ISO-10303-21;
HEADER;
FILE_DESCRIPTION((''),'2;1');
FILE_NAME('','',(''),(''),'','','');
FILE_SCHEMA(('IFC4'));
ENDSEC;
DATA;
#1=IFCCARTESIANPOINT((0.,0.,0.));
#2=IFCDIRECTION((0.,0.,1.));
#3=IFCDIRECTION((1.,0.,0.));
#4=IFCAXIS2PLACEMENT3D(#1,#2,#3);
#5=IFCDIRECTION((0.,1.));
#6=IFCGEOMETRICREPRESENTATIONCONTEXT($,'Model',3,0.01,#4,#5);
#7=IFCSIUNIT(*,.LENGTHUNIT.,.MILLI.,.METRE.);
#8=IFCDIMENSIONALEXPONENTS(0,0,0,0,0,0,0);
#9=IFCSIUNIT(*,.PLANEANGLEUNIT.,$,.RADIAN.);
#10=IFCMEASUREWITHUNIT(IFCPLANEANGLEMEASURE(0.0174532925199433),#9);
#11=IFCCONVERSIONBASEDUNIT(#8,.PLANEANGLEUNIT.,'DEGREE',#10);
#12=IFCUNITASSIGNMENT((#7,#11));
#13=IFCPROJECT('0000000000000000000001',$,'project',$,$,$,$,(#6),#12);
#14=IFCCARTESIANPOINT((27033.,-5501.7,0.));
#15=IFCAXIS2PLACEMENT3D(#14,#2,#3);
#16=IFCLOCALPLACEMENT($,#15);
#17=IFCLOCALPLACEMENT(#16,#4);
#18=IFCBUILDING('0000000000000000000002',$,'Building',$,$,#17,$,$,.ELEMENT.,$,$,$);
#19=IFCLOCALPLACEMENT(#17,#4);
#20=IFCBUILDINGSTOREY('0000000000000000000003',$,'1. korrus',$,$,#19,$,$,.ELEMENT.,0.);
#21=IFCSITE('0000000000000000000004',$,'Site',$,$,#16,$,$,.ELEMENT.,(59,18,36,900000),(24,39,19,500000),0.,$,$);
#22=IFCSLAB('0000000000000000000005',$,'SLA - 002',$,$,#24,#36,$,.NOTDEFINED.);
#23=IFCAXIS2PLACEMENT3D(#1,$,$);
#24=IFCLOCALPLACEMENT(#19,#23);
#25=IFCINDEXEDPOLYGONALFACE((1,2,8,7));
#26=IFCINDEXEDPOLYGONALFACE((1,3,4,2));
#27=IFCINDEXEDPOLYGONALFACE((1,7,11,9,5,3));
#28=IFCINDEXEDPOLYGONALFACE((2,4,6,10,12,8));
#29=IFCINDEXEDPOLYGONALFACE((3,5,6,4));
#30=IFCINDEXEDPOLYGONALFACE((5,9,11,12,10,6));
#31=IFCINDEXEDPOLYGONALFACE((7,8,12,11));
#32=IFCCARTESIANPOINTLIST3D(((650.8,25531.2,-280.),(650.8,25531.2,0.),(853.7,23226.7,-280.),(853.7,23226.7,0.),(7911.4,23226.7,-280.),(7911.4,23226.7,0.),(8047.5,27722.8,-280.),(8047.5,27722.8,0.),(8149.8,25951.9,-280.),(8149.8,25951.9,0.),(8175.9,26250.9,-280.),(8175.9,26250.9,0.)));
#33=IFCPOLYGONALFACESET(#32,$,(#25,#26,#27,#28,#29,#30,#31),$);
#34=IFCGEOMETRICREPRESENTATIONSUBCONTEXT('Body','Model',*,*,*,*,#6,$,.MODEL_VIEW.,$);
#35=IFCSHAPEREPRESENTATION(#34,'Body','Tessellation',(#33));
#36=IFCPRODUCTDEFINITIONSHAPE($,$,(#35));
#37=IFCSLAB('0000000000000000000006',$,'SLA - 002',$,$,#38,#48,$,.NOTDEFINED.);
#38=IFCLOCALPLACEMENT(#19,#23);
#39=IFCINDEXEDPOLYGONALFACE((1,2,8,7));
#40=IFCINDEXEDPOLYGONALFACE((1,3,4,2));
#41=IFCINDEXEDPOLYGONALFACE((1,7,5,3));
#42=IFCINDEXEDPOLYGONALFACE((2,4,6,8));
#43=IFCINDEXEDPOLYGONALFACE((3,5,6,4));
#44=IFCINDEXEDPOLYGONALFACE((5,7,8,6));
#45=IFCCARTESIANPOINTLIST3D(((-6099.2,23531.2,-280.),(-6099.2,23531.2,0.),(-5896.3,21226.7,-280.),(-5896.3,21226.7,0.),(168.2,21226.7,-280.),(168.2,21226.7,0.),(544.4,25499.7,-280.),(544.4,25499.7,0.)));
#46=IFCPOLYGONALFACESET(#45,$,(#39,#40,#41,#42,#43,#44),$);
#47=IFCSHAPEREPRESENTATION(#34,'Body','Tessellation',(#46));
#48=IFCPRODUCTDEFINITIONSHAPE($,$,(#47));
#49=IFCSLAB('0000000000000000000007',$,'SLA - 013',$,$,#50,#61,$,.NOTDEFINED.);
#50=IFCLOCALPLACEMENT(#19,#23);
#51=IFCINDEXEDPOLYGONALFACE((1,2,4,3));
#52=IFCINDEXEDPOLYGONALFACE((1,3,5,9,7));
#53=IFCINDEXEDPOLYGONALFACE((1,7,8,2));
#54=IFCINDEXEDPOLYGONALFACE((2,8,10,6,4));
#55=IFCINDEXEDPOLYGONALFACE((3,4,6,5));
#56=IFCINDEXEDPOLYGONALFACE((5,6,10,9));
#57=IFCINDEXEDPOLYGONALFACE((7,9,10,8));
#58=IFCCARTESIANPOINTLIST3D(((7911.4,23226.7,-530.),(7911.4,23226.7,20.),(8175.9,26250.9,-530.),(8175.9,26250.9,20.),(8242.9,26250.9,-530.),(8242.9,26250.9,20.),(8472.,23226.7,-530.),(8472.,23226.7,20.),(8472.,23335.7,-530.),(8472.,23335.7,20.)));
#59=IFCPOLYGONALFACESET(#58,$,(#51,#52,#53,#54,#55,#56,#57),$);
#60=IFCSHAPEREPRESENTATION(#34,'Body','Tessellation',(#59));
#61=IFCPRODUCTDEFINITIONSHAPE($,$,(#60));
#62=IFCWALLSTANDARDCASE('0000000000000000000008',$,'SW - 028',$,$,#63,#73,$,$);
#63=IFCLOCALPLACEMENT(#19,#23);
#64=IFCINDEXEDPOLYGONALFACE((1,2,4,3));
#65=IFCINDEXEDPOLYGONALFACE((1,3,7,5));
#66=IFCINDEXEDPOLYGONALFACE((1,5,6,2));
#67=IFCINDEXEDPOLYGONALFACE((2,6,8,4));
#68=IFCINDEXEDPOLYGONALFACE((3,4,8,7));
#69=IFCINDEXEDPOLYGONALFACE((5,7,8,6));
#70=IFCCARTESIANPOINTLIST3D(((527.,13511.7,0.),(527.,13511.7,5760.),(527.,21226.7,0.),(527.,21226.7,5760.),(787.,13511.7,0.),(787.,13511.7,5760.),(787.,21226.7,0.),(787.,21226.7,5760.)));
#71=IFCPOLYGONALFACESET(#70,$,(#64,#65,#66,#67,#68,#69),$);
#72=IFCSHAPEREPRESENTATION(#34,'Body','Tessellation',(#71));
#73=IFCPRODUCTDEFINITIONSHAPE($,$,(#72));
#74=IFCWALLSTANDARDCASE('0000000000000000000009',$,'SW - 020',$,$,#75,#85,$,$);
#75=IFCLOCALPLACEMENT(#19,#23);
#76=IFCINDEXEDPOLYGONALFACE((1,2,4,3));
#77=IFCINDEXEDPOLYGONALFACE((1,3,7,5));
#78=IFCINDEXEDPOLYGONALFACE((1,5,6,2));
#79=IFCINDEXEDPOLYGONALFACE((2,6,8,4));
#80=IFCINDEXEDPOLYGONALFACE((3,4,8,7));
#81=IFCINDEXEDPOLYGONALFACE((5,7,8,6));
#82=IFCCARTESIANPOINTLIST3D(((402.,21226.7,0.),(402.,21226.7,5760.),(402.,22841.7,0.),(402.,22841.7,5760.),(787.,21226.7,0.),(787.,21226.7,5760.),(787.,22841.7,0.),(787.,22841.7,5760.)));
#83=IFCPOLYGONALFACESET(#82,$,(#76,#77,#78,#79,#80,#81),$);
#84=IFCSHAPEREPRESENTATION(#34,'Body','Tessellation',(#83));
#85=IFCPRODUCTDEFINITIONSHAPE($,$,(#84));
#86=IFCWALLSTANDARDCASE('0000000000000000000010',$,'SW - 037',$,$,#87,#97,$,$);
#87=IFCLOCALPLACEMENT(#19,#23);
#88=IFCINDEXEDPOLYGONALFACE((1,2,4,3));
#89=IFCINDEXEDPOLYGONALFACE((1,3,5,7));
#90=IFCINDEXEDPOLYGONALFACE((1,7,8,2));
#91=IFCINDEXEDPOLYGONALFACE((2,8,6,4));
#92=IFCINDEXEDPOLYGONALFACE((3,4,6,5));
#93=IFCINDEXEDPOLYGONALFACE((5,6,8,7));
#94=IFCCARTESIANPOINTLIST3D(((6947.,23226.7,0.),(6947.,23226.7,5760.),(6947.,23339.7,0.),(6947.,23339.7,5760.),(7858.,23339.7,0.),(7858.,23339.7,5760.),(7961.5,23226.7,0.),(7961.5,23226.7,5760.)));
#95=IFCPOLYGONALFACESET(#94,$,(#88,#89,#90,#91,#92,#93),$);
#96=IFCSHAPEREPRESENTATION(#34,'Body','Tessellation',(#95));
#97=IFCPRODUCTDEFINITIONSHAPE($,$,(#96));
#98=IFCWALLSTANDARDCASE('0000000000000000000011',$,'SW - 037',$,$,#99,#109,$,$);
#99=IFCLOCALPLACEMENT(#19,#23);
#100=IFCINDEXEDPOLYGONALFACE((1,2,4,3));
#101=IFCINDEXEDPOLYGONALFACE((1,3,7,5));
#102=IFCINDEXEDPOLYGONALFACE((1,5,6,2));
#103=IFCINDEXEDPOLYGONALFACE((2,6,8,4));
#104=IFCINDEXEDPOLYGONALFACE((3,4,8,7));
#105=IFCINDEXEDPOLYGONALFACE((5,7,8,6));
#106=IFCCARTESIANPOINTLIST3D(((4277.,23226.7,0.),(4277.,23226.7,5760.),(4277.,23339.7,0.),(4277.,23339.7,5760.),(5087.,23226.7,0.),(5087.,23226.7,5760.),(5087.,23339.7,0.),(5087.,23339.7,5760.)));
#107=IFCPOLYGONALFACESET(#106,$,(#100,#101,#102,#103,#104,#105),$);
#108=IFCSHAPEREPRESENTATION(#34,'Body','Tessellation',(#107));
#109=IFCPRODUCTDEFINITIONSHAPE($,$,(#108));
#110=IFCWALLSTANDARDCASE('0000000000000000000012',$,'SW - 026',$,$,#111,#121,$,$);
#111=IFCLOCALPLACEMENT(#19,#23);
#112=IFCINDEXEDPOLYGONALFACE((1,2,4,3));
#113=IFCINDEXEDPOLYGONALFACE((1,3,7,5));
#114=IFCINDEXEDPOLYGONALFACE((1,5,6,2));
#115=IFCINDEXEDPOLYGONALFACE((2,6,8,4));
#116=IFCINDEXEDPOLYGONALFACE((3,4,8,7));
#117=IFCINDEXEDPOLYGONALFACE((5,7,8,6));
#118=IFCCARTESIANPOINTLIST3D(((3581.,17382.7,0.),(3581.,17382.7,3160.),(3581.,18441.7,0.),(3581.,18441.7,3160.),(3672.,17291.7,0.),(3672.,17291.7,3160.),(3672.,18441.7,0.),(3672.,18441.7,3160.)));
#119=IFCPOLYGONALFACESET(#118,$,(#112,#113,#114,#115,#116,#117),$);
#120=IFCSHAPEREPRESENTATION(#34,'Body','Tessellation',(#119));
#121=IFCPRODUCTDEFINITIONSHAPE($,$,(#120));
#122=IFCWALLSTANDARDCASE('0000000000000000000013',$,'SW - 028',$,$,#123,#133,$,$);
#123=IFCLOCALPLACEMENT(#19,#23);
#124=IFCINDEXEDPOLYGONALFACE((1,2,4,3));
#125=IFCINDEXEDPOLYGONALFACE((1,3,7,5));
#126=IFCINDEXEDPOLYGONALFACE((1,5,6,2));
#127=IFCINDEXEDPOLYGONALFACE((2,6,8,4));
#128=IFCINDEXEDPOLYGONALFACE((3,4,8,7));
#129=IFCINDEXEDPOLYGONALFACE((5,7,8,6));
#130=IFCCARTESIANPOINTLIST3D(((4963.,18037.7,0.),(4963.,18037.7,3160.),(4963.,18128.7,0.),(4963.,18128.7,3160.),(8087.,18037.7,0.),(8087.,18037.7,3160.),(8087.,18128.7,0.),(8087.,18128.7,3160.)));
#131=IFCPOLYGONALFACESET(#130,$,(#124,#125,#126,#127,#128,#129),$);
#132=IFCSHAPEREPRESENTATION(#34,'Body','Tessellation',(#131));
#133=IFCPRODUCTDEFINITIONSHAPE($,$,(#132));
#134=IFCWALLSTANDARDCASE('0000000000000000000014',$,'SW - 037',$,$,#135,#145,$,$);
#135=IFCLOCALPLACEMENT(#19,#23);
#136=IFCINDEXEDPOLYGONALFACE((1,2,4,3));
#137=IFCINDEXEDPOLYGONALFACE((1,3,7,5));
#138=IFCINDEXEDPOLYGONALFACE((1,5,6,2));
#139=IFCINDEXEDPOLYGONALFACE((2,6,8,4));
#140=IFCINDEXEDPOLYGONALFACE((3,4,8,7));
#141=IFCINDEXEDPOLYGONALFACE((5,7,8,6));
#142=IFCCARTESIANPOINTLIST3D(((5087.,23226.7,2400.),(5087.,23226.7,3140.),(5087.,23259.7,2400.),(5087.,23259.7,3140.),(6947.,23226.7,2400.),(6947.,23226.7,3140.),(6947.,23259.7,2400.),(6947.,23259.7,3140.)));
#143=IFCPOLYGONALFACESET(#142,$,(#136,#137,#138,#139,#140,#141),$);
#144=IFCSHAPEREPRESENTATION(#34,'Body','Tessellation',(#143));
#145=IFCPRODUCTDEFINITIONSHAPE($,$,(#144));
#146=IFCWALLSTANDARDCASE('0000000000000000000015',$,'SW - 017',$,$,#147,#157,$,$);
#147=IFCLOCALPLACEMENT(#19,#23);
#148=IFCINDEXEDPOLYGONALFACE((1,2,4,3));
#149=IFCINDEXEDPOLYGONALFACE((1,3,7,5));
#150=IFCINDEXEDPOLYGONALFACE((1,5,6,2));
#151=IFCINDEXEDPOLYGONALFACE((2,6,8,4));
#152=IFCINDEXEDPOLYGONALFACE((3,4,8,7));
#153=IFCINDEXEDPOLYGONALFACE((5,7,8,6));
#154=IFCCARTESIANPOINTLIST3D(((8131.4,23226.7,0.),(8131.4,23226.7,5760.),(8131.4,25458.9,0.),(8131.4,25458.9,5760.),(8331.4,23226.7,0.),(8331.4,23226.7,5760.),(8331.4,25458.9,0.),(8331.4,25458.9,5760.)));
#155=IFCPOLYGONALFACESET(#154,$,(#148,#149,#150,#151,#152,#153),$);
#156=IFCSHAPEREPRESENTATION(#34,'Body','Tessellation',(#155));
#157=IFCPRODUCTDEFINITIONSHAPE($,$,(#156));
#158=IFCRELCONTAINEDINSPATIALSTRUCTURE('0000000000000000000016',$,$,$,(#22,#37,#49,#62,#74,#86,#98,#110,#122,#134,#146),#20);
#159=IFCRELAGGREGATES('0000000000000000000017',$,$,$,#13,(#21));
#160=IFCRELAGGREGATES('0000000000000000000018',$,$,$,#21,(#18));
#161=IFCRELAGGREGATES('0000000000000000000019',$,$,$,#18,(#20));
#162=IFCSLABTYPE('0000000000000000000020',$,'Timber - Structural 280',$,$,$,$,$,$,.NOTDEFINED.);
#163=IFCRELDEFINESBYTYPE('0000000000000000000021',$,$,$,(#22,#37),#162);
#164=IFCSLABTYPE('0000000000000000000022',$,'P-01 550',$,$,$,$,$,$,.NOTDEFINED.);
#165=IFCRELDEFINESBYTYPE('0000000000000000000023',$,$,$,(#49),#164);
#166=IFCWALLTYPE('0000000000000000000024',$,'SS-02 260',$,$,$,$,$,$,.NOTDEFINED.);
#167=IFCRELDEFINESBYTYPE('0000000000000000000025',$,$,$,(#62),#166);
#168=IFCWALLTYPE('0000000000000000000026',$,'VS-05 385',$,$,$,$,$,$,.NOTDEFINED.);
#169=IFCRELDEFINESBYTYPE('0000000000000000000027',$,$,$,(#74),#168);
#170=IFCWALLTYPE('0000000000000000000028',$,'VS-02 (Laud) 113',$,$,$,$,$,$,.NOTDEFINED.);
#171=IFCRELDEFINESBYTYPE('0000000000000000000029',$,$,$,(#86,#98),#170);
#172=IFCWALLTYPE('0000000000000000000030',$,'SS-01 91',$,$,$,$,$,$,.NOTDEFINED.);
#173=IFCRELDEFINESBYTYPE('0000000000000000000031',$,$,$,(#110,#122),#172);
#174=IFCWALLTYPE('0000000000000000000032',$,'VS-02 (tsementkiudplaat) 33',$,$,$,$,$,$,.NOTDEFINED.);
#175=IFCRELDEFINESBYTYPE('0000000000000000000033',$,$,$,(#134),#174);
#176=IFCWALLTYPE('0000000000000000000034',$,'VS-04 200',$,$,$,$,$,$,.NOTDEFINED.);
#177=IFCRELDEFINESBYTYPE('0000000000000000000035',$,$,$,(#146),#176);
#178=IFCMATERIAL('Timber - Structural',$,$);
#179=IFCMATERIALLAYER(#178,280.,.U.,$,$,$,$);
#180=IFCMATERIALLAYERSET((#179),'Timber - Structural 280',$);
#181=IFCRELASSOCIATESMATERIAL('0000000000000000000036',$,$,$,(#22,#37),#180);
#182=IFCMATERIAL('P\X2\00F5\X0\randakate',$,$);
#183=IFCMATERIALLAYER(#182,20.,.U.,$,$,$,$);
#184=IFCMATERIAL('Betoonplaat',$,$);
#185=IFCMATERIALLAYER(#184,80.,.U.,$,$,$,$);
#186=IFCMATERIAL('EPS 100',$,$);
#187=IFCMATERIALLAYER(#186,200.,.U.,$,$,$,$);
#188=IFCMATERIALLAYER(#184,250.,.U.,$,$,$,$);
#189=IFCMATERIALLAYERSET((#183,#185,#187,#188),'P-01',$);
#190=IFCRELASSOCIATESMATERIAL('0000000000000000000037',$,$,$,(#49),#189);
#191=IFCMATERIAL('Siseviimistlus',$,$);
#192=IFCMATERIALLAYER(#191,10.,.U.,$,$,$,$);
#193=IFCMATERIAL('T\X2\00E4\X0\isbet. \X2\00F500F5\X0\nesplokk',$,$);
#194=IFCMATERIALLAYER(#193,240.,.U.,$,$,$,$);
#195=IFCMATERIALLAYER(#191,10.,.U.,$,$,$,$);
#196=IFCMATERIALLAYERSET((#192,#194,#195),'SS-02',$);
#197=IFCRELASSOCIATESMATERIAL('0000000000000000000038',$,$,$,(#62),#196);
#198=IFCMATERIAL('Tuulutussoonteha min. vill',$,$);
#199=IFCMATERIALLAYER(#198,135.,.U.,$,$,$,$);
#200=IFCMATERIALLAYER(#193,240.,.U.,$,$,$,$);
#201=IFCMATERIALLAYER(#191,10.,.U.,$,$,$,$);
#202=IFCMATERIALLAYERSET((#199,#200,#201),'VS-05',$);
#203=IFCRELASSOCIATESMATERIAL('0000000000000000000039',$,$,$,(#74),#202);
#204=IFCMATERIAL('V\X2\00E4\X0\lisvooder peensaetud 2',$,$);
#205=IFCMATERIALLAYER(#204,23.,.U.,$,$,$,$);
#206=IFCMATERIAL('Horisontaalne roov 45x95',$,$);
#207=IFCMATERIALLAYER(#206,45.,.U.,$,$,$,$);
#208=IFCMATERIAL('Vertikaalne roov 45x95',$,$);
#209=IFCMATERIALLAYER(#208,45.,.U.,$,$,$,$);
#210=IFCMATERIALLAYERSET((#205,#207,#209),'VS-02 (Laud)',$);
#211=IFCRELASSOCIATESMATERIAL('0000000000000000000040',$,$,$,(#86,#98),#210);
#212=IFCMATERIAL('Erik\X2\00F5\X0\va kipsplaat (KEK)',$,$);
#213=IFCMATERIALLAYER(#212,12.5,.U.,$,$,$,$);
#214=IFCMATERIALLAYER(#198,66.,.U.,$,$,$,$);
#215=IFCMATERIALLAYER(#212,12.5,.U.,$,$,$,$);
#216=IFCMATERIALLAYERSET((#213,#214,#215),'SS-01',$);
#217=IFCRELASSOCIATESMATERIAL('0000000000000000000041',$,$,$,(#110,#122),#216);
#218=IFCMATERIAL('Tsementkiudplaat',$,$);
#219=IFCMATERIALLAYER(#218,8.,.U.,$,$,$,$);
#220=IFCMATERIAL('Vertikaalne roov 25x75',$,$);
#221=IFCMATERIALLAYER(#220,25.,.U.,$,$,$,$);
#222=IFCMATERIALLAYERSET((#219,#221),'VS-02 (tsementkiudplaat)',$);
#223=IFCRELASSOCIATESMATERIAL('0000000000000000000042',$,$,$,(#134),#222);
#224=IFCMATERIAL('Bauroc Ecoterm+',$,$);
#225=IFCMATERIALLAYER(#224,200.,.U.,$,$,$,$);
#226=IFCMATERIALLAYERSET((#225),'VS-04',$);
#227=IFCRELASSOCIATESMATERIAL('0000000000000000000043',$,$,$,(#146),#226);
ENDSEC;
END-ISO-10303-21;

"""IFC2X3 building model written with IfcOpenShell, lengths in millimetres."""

from ifc_helpers import new_model, entity, si_unit, converted_unit, direction, frame, origin_with_axes, place, context, subcontext, project, spatial, polyline, outline, extrude, material, layer, layer_set, layer_usage, type_object, element, save


model = new_model("IFC2X3")

# Units and contexts
model_context = context("Model", 3, precision=0.01, world=origin_with_axes(), true_north=direction((0.0, 1.0)))
body_context = subcontext(model_context, "Body", "Model", "MODEL_VIEW")
ifc_project = project(units=[si_unit("LENGTHUNIT", "METRE", prefix="MILLI"), converted_unit("PLANEANGLEUNIT", "DEGREE", entity("IfcPlaneAngleMeasure", 0.0174532925199433), si_unit("PLANEANGLEUNIT", "RADIAN"), dimensions=[0, 0, 0, 0, 0, 0, 0])], contexts=[model_context])

# Site, building, storey
site_placement = place(None, frame((27033.0, -5501.7, 0.0), z_axis=(0.0, 0.0, 1.0), x_axis=(1.0, 0.0, 0.0)))
site = spatial("IfcSite", under=ifc_project, at=site_placement, Name="Site", CompositionType="ELEMENT", RefLatitude=(59, 18, 36, 900000), RefLongitude=(24, 39, 19, 500000), RefElevation=0.0)
building_placement = place(site_placement, origin_with_axes())
building = spatial("IfcBuilding", under=site, at=building_placement, Name="Building", CompositionType="ELEMENT")
storey_placement = place(building_placement, origin_with_axes())
storey = spatial("IfcBuildingStorey", under=building, at=storey_placement, Name="1. korrus", CompositionType="ELEMENT", Elevation=0.0)

# Slabs
ifc_material_1 = material(Name="Timber - Structural")
ifc_layer_1 = layer(ifc_material_1, 280.0, ventilated="UNKNOWN")
ifc_layer_set_1 = layer_set([ifc_layer_1], Name="Timber - Structural 280")
ifc_layer_usage_1 = layer_usage(ifc_layer_set_1, "AXIS3", "NEGATIVE", 280.0)
slab_type_1 = type_object("IfcSlabType", Name="Timber - Structural 280", PredefinedType="NOTDEFINED")
slab_1_placement = place(storey_placement, frame((8047.5, 27722.8, 0.0), z_axis=(0.0, 0.0, 1.0), x_axis=(1.0, 0.0, 0.0)))
element("IfcSlab", 1, at=slab_1_placement, inside=storey, type_object=slab_type_1, material=ifc_layer_usage_1, Name="SLA - 002", PredefinedType="NOTDEFINED", context=body_context, shape_type="SweptSolid", body=[
    extrude(outline(polyline([(0.0, 0.0), (-7396.8, -2191.6), (-7193.8, -4496.1), (-136.2, -4496.1), (102.3, -1770.9), (128.4, -1471.9), (0.0, 0.0)])), frame((0.0, 0.0, -280.0), z_axis=(0.0, 0.0, 1.0), x_axis=(1.0, 0.0, 0.0)), (0.0, 0.0, 1.0), 280.0),
])
ifc_layer_usage_2 = layer_usage(ifc_layer_set_1, "AXIS3", "NEGATIVE", 280.0)
slab_2_placement = place(storey_placement, frame((544.4, 25499.7, 0.0), z_axis=(0.0, 0.0, 1.0), x_axis=(1.0, 0.0, 0.0)))
element("IfcSlab", 2, at=slab_2_placement, inside=storey, type_object=slab_type_1, material=ifc_layer_usage_2, Name="SLA - 002", PredefinedType="NOTDEFINED", context=body_context, shape_type="SweptSolid", body=[
    extrude(outline(polyline([(0.0, 0.0), (-6643.7, -1968.5), (-6440.8, -4273.0), (-376.2, -4273.0), (0.0, 0.0)])), frame((0.0, 0.0, -280.0), z_axis=(0.0, 0.0, 1.0), x_axis=(1.0, 0.0, 0.0)), (0.0, 0.0, 1.0), 280.0),
])
ifc_material_2 = material(Name="Põrandakate")
ifc_layer_2 = layer(ifc_material_2, 20.0, ventilated="UNKNOWN")
ifc_material_3 = material(Name="Betoonplaat")
ifc_layer_3 = layer(ifc_material_3, 80.0, ventilated="UNKNOWN")
ifc_material_4 = material(Name="EPS 100")
ifc_layer_4 = layer(ifc_material_4, 200.0, ventilated="UNKNOWN")
ifc_layer_5 = layer(ifc_material_3, 250.0, ventilated="UNKNOWN")
ifc_layer_set_2 = layer_set([ifc_layer_2, ifc_layer_3, ifc_layer_4, ifc_layer_5], Name="P-01")
ifc_layer_usage_3 = layer_usage(ifc_layer_set_2, "AXIS3", "NEGATIVE", 550.0)
slab_type_2 = type_object("IfcSlabType", Name="P-01 550", PredefinedType="NOTDEFINED")
slab_3_placement = place(storey_placement, frame((7911.4, 23226.7, 0.0), z_axis=(0.0, 0.0, 1.0), x_axis=(1.0, 0.0, 0.0)))
element("IfcSlab", 3, at=slab_3_placement, inside=storey, type_object=slab_type_2, material=ifc_layer_usage_3, Name="SLA - 013", PredefinedType="NOTDEFINED", context=body_context, shape_type="SweptSolid", body=[
    extrude(outline(polyline([(0.0, 0.0), (560.6, 0.0), (560.6, 109.0), (331.5, 3024.2), (264.6, 3024.2), (0.0, 0.0)])), frame((0.0, 0.0, -530.0), z_axis=(0.0, 0.0, 1.0), x_axis=(1.0, 0.0, 0.0)), (0.0, 0.0, 1.0), 550.0),
])

# Wall
ifc_material_5 = material(Name="Siseviimistlus")
ifc_layer_6 = layer(ifc_material_5, 10.0, ventilated="UNKNOWN")
ifc_material_6 = material(Name="Täisbet. õõnesplokk")
ifc_layer_7 = layer(ifc_material_6, 240.0, ventilated="UNKNOWN")
ifc_layer_8 = layer(ifc_material_5, 10.0, ventilated="UNKNOWN")
ifc_layer_set_3 = layer_set([ifc_layer_6, ifc_layer_7, ifc_layer_8], Name="SS-02")
ifc_layer_usage_4 = layer_usage(ifc_layer_set_3, "AXIS2", "POSITIVE", -260.0)
wall_type_1 = type_object("IfcWallType", Name="SS-02 260", PredefinedType="NOTDEFINED")
wall_1_placement = place(storey_placement, frame((787.0, 21226.7, 0.0), z_axis=(0.0, 0.0, 1.0), x_axis=(0.0, -1.0, 0.0)))
element("IfcWallStandardCase", 4, at=wall_1_placement, inside=storey, type_object=wall_type_1, material=ifc_layer_usage_4, Name="SW - 028", context=body_context, shape_type="SweptSolid", body=[
    extrude(outline(polyline([(0.0, -260.0), (7715.0, -260.0), (7715.0, 0.0), (0.0, 0.0), (0.0, -260.0)])), origin_with_axes(), (0.0, 0.0, 1.0), 5760.0),
])

# Shared definitions
ifc_material_7 = material(Name="Bauroc Ecoterm+")

# Walls
ifc_material_8 = material(Name="Tuulutussoonteha min. vill")
ifc_layer_9 = layer(ifc_material_8, 135.0, ventilated="UNKNOWN")
ifc_layer_10 = layer(ifc_material_6, 240.0, ventilated="UNKNOWN")
ifc_layer_11 = layer(ifc_material_5, 10.0, ventilated="UNKNOWN")
ifc_layer_set_4 = layer_set([ifc_layer_9, ifc_layer_10, ifc_layer_11], Name="VS-05")
ifc_layer_usage_5 = layer_usage(ifc_layer_set_4, "AXIS2", "POSITIVE", -385.0)
wall_type_2 = type_object("IfcWallType", Name="VS-05 385", PredefinedType="NOTDEFINED")
wall_2_placement = place(storey_placement, frame((787.0, 23226.7, 0.0), z_axis=(0.0, 0.0, 1.0), x_axis=(0.0, -1.0, 0.0)))
element("IfcWallStandardCase", 5, at=wall_2_placement, inside=storey, type_object=wall_type_2, material=ifc_layer_usage_5, Name="SW - 020", context=body_context, shape_type="SweptSolid", body=[
    extrude(outline(polyline([(385.0, -385.0), (2000.0, -385.0), (2000.0, 0.0), (385.0, 0.0), (385.0, -385.0)])), origin_with_axes(), (0.0, 0.0, 1.0), 5760.0),
])
ifc_material_9 = material(Name="Välisvooder peensaetud 2")
ifc_layer_12 = layer(ifc_material_9, 23.0, ventilated="UNKNOWN")
ifc_material_10 = material(Name="Horisontaalne roov 45x95")
ifc_layer_13 = layer(ifc_material_10, 45.0, ventilated="UNKNOWN")
ifc_material_11 = material(Name="Vertikaalne roov 45x95")
ifc_layer_14 = layer(ifc_material_11, 45.0, ventilated="UNKNOWN")
ifc_layer_set_5 = layer_set([ifc_layer_12, ifc_layer_13, ifc_layer_14], Name="VS-02 (Laud)")
wall_type_3 = type_object("IfcWallType", Name="VS-02 (Laud) 113", PredefinedType="NOTDEFINED")
ifc_layer_usage_6 = layer_usage(ifc_layer_set_5, "AXIS2", "NEGATIVE", 113.0)
wall_3_placement = place(storey_placement, frame((6947.0, 23226.7, 0.0), z_axis=(0.0, 0.0, 1.0), x_axis=(1.0, 0.0, 0.0)))
element("IfcWallStandardCase", 6, at=wall_3_placement, inside=storey, type_object=wall_type_3, material=ifc_layer_usage_6, Name="SW - 037", context=body_context, shape_type="SweptSolid", body=[
    extrude(outline(polyline([(0.0, 0.0), (1014.5, 0.0), (911.0, 113.0), (0.0, 113.0), (0.0, 0.0)])), origin_with_axes(), (0.0, 0.0, 1.0), 5760.0),
])
ifc_layer_usage_7 = layer_usage(ifc_layer_set_5, "AXIS2", "NEGATIVE", 113.0)
wall_4_placement = place(storey_placement, frame((4277.0, 23226.7, 0.0), z_axis=(0.0, 0.0, 1.0), x_axis=(1.0, 0.0, 0.0)))
element("IfcWallStandardCase", 7, at=wall_4_placement, inside=storey, type_object=wall_type_3, material=ifc_layer_usage_7, Name="SW - 037", context=body_context, shape_type="SweptSolid", body=[
    extrude(outline(polyline([(0.0, 0.0), (810.0, 0.0), (810.0, 113.0), (0.0, 113.0), (0.0, 0.0)])), origin_with_axes(), (0.0, 0.0, 1.0), 5760.0),
])
ifc_material_12 = material(Name="Erikõva kipsplaat (KEK)")
ifc_layer_15 = layer(ifc_material_12, 12.5, ventilated="UNKNOWN")
ifc_layer_16 = layer(ifc_material_8, 66.0, ventilated="UNKNOWN")
ifc_layer_17 = layer(ifc_material_12, 12.5, ventilated="UNKNOWN")
ifc_layer_set_6 = layer_set([ifc_layer_15, ifc_layer_16, ifc_layer_17], Name="SS-01")
ifc_layer_usage_8 = layer_usage(ifc_layer_set_6, "AXIS2", "POSITIVE", -91.0)
wall_type_4 = type_object("IfcWallType", Name="SS-01 91", PredefinedType="NOTDEFINED")
wall_5_placement = place(storey_placement, frame((3672.0, 18441.7, 0.0), z_axis=(0.0, 0.0, 1.0), x_axis=(0.0, -1.0, 0.0)))
element("IfcWallStandardCase", 8, at=wall_5_placement, inside=storey, type_object=wall_type_4, material=ifc_layer_usage_8, Name="SW - 026", context=body_context, shape_type="SweptSolid", body=[
    extrude(outline(polyline([(0.0, -91.0), (1059.0, -91.0), (1150.0, 0.0), (0.0, 0.0), (0.0, -91.0)])), origin_with_axes(), (0.0, 0.0, 1.0), 3160.0),
])
ifc_layer_usage_9 = layer_usage(ifc_layer_set_6, "AXIS2", "POSITIVE", -91.0)
wall_6_placement = place(storey_placement, frame((8087.0, 18037.7, 0.0), z_axis=(0.0, 0.0, 1.0), x_axis=(-1.0, 0.0, 0.0)))
element("IfcWallStandardCase", 9, at=wall_6_placement, inside=storey, type_object=wall_type_4, material=ifc_layer_usage_9, Name="SW - 028", context=body_context, shape_type="SweptSolid", body=[
    extrude(outline(polyline([(0.0, -91.0), (3124.0, -91.0), (3124.0, 0.0), (0.0, 0.0), (0.0, -91.0)])), origin_with_axes(), (0.0, 0.0, 1.0), 3160.0),
])
ifc_material_13 = material(Name="Tsementkiudplaat")
ifc_layer_18 = layer(ifc_material_13, 8.0, ventilated="UNKNOWN")
ifc_material_14 = material(Name="Vertikaalne roov 25x75")
ifc_layer_19 = layer(ifc_material_14, 25.0, ventilated="UNKNOWN")
ifc_layer_set_7 = layer_set([ifc_layer_18, ifc_layer_19], Name="VS-02 (tsementkiudplaat)")
ifc_layer_usage_10 = layer_usage(ifc_layer_set_7, "AXIS2", "NEGATIVE", 33.0)
wall_type_5 = type_object("IfcWallType", Name="VS-02 (tsementkiudplaat) 33", PredefinedType="NOTDEFINED")
wall_7_placement = place(storey_placement, frame((5087.0, 23226.7, 2400.0), z_axis=(0.0, 0.0, 1.0), x_axis=(1.0, -0.000004, 0.0)))
element("IfcWallStandardCase", 10, at=wall_7_placement, inside=storey, type_object=wall_type_5, material=ifc_layer_usage_10, Name="SW - 037", context=body_context, shape_type="SweptSolid", body=[
    extrude(outline(polyline([(0.0, 0.0), (1860.0, 0.0), (1860.0, 33.0), (0.0, 33.0), (0.0, 0.0)])), origin_with_axes(), (0.0, 0.0, 1.0), 740.0),
])
ifc_layer_20 = layer(ifc_material_7, 200.0, ventilated="UNKNOWN")
ifc_layer_set_8 = layer_set([ifc_layer_20], Name="VS-04")
ifc_layer_usage_11 = layer_usage(ifc_layer_set_8, "AXIS2", "NEGATIVE", 0.0)
wall_type_6 = type_object("IfcWallType", Name="VS-04 200", PredefinedType="NOTDEFINED")
wall_8_placement = place(storey_placement, frame((8131.4, 23226.7, 0.0), z_axis=(0.0, 0.0, 1.0), x_axis=(0.0, 1.0, 0.0)))
element("IfcWallStandardCase", 11, at=wall_8_placement, inside=storey, type_object=wall_type_6, material=ifc_layer_usage_11, Name="SW - 017", context=body_context, shape_type="SweptSolid", body=[
    extrude(outline(polyline([(0.0, -200.0), (2232.2, -200.0), (2232.2, 0.0), (0.0, 0.0), (0.0, -200.0)])), origin_with_axes(), (0.0, 0.0, 1.0), 5760.0),
])

save(model, "model.ifc")
